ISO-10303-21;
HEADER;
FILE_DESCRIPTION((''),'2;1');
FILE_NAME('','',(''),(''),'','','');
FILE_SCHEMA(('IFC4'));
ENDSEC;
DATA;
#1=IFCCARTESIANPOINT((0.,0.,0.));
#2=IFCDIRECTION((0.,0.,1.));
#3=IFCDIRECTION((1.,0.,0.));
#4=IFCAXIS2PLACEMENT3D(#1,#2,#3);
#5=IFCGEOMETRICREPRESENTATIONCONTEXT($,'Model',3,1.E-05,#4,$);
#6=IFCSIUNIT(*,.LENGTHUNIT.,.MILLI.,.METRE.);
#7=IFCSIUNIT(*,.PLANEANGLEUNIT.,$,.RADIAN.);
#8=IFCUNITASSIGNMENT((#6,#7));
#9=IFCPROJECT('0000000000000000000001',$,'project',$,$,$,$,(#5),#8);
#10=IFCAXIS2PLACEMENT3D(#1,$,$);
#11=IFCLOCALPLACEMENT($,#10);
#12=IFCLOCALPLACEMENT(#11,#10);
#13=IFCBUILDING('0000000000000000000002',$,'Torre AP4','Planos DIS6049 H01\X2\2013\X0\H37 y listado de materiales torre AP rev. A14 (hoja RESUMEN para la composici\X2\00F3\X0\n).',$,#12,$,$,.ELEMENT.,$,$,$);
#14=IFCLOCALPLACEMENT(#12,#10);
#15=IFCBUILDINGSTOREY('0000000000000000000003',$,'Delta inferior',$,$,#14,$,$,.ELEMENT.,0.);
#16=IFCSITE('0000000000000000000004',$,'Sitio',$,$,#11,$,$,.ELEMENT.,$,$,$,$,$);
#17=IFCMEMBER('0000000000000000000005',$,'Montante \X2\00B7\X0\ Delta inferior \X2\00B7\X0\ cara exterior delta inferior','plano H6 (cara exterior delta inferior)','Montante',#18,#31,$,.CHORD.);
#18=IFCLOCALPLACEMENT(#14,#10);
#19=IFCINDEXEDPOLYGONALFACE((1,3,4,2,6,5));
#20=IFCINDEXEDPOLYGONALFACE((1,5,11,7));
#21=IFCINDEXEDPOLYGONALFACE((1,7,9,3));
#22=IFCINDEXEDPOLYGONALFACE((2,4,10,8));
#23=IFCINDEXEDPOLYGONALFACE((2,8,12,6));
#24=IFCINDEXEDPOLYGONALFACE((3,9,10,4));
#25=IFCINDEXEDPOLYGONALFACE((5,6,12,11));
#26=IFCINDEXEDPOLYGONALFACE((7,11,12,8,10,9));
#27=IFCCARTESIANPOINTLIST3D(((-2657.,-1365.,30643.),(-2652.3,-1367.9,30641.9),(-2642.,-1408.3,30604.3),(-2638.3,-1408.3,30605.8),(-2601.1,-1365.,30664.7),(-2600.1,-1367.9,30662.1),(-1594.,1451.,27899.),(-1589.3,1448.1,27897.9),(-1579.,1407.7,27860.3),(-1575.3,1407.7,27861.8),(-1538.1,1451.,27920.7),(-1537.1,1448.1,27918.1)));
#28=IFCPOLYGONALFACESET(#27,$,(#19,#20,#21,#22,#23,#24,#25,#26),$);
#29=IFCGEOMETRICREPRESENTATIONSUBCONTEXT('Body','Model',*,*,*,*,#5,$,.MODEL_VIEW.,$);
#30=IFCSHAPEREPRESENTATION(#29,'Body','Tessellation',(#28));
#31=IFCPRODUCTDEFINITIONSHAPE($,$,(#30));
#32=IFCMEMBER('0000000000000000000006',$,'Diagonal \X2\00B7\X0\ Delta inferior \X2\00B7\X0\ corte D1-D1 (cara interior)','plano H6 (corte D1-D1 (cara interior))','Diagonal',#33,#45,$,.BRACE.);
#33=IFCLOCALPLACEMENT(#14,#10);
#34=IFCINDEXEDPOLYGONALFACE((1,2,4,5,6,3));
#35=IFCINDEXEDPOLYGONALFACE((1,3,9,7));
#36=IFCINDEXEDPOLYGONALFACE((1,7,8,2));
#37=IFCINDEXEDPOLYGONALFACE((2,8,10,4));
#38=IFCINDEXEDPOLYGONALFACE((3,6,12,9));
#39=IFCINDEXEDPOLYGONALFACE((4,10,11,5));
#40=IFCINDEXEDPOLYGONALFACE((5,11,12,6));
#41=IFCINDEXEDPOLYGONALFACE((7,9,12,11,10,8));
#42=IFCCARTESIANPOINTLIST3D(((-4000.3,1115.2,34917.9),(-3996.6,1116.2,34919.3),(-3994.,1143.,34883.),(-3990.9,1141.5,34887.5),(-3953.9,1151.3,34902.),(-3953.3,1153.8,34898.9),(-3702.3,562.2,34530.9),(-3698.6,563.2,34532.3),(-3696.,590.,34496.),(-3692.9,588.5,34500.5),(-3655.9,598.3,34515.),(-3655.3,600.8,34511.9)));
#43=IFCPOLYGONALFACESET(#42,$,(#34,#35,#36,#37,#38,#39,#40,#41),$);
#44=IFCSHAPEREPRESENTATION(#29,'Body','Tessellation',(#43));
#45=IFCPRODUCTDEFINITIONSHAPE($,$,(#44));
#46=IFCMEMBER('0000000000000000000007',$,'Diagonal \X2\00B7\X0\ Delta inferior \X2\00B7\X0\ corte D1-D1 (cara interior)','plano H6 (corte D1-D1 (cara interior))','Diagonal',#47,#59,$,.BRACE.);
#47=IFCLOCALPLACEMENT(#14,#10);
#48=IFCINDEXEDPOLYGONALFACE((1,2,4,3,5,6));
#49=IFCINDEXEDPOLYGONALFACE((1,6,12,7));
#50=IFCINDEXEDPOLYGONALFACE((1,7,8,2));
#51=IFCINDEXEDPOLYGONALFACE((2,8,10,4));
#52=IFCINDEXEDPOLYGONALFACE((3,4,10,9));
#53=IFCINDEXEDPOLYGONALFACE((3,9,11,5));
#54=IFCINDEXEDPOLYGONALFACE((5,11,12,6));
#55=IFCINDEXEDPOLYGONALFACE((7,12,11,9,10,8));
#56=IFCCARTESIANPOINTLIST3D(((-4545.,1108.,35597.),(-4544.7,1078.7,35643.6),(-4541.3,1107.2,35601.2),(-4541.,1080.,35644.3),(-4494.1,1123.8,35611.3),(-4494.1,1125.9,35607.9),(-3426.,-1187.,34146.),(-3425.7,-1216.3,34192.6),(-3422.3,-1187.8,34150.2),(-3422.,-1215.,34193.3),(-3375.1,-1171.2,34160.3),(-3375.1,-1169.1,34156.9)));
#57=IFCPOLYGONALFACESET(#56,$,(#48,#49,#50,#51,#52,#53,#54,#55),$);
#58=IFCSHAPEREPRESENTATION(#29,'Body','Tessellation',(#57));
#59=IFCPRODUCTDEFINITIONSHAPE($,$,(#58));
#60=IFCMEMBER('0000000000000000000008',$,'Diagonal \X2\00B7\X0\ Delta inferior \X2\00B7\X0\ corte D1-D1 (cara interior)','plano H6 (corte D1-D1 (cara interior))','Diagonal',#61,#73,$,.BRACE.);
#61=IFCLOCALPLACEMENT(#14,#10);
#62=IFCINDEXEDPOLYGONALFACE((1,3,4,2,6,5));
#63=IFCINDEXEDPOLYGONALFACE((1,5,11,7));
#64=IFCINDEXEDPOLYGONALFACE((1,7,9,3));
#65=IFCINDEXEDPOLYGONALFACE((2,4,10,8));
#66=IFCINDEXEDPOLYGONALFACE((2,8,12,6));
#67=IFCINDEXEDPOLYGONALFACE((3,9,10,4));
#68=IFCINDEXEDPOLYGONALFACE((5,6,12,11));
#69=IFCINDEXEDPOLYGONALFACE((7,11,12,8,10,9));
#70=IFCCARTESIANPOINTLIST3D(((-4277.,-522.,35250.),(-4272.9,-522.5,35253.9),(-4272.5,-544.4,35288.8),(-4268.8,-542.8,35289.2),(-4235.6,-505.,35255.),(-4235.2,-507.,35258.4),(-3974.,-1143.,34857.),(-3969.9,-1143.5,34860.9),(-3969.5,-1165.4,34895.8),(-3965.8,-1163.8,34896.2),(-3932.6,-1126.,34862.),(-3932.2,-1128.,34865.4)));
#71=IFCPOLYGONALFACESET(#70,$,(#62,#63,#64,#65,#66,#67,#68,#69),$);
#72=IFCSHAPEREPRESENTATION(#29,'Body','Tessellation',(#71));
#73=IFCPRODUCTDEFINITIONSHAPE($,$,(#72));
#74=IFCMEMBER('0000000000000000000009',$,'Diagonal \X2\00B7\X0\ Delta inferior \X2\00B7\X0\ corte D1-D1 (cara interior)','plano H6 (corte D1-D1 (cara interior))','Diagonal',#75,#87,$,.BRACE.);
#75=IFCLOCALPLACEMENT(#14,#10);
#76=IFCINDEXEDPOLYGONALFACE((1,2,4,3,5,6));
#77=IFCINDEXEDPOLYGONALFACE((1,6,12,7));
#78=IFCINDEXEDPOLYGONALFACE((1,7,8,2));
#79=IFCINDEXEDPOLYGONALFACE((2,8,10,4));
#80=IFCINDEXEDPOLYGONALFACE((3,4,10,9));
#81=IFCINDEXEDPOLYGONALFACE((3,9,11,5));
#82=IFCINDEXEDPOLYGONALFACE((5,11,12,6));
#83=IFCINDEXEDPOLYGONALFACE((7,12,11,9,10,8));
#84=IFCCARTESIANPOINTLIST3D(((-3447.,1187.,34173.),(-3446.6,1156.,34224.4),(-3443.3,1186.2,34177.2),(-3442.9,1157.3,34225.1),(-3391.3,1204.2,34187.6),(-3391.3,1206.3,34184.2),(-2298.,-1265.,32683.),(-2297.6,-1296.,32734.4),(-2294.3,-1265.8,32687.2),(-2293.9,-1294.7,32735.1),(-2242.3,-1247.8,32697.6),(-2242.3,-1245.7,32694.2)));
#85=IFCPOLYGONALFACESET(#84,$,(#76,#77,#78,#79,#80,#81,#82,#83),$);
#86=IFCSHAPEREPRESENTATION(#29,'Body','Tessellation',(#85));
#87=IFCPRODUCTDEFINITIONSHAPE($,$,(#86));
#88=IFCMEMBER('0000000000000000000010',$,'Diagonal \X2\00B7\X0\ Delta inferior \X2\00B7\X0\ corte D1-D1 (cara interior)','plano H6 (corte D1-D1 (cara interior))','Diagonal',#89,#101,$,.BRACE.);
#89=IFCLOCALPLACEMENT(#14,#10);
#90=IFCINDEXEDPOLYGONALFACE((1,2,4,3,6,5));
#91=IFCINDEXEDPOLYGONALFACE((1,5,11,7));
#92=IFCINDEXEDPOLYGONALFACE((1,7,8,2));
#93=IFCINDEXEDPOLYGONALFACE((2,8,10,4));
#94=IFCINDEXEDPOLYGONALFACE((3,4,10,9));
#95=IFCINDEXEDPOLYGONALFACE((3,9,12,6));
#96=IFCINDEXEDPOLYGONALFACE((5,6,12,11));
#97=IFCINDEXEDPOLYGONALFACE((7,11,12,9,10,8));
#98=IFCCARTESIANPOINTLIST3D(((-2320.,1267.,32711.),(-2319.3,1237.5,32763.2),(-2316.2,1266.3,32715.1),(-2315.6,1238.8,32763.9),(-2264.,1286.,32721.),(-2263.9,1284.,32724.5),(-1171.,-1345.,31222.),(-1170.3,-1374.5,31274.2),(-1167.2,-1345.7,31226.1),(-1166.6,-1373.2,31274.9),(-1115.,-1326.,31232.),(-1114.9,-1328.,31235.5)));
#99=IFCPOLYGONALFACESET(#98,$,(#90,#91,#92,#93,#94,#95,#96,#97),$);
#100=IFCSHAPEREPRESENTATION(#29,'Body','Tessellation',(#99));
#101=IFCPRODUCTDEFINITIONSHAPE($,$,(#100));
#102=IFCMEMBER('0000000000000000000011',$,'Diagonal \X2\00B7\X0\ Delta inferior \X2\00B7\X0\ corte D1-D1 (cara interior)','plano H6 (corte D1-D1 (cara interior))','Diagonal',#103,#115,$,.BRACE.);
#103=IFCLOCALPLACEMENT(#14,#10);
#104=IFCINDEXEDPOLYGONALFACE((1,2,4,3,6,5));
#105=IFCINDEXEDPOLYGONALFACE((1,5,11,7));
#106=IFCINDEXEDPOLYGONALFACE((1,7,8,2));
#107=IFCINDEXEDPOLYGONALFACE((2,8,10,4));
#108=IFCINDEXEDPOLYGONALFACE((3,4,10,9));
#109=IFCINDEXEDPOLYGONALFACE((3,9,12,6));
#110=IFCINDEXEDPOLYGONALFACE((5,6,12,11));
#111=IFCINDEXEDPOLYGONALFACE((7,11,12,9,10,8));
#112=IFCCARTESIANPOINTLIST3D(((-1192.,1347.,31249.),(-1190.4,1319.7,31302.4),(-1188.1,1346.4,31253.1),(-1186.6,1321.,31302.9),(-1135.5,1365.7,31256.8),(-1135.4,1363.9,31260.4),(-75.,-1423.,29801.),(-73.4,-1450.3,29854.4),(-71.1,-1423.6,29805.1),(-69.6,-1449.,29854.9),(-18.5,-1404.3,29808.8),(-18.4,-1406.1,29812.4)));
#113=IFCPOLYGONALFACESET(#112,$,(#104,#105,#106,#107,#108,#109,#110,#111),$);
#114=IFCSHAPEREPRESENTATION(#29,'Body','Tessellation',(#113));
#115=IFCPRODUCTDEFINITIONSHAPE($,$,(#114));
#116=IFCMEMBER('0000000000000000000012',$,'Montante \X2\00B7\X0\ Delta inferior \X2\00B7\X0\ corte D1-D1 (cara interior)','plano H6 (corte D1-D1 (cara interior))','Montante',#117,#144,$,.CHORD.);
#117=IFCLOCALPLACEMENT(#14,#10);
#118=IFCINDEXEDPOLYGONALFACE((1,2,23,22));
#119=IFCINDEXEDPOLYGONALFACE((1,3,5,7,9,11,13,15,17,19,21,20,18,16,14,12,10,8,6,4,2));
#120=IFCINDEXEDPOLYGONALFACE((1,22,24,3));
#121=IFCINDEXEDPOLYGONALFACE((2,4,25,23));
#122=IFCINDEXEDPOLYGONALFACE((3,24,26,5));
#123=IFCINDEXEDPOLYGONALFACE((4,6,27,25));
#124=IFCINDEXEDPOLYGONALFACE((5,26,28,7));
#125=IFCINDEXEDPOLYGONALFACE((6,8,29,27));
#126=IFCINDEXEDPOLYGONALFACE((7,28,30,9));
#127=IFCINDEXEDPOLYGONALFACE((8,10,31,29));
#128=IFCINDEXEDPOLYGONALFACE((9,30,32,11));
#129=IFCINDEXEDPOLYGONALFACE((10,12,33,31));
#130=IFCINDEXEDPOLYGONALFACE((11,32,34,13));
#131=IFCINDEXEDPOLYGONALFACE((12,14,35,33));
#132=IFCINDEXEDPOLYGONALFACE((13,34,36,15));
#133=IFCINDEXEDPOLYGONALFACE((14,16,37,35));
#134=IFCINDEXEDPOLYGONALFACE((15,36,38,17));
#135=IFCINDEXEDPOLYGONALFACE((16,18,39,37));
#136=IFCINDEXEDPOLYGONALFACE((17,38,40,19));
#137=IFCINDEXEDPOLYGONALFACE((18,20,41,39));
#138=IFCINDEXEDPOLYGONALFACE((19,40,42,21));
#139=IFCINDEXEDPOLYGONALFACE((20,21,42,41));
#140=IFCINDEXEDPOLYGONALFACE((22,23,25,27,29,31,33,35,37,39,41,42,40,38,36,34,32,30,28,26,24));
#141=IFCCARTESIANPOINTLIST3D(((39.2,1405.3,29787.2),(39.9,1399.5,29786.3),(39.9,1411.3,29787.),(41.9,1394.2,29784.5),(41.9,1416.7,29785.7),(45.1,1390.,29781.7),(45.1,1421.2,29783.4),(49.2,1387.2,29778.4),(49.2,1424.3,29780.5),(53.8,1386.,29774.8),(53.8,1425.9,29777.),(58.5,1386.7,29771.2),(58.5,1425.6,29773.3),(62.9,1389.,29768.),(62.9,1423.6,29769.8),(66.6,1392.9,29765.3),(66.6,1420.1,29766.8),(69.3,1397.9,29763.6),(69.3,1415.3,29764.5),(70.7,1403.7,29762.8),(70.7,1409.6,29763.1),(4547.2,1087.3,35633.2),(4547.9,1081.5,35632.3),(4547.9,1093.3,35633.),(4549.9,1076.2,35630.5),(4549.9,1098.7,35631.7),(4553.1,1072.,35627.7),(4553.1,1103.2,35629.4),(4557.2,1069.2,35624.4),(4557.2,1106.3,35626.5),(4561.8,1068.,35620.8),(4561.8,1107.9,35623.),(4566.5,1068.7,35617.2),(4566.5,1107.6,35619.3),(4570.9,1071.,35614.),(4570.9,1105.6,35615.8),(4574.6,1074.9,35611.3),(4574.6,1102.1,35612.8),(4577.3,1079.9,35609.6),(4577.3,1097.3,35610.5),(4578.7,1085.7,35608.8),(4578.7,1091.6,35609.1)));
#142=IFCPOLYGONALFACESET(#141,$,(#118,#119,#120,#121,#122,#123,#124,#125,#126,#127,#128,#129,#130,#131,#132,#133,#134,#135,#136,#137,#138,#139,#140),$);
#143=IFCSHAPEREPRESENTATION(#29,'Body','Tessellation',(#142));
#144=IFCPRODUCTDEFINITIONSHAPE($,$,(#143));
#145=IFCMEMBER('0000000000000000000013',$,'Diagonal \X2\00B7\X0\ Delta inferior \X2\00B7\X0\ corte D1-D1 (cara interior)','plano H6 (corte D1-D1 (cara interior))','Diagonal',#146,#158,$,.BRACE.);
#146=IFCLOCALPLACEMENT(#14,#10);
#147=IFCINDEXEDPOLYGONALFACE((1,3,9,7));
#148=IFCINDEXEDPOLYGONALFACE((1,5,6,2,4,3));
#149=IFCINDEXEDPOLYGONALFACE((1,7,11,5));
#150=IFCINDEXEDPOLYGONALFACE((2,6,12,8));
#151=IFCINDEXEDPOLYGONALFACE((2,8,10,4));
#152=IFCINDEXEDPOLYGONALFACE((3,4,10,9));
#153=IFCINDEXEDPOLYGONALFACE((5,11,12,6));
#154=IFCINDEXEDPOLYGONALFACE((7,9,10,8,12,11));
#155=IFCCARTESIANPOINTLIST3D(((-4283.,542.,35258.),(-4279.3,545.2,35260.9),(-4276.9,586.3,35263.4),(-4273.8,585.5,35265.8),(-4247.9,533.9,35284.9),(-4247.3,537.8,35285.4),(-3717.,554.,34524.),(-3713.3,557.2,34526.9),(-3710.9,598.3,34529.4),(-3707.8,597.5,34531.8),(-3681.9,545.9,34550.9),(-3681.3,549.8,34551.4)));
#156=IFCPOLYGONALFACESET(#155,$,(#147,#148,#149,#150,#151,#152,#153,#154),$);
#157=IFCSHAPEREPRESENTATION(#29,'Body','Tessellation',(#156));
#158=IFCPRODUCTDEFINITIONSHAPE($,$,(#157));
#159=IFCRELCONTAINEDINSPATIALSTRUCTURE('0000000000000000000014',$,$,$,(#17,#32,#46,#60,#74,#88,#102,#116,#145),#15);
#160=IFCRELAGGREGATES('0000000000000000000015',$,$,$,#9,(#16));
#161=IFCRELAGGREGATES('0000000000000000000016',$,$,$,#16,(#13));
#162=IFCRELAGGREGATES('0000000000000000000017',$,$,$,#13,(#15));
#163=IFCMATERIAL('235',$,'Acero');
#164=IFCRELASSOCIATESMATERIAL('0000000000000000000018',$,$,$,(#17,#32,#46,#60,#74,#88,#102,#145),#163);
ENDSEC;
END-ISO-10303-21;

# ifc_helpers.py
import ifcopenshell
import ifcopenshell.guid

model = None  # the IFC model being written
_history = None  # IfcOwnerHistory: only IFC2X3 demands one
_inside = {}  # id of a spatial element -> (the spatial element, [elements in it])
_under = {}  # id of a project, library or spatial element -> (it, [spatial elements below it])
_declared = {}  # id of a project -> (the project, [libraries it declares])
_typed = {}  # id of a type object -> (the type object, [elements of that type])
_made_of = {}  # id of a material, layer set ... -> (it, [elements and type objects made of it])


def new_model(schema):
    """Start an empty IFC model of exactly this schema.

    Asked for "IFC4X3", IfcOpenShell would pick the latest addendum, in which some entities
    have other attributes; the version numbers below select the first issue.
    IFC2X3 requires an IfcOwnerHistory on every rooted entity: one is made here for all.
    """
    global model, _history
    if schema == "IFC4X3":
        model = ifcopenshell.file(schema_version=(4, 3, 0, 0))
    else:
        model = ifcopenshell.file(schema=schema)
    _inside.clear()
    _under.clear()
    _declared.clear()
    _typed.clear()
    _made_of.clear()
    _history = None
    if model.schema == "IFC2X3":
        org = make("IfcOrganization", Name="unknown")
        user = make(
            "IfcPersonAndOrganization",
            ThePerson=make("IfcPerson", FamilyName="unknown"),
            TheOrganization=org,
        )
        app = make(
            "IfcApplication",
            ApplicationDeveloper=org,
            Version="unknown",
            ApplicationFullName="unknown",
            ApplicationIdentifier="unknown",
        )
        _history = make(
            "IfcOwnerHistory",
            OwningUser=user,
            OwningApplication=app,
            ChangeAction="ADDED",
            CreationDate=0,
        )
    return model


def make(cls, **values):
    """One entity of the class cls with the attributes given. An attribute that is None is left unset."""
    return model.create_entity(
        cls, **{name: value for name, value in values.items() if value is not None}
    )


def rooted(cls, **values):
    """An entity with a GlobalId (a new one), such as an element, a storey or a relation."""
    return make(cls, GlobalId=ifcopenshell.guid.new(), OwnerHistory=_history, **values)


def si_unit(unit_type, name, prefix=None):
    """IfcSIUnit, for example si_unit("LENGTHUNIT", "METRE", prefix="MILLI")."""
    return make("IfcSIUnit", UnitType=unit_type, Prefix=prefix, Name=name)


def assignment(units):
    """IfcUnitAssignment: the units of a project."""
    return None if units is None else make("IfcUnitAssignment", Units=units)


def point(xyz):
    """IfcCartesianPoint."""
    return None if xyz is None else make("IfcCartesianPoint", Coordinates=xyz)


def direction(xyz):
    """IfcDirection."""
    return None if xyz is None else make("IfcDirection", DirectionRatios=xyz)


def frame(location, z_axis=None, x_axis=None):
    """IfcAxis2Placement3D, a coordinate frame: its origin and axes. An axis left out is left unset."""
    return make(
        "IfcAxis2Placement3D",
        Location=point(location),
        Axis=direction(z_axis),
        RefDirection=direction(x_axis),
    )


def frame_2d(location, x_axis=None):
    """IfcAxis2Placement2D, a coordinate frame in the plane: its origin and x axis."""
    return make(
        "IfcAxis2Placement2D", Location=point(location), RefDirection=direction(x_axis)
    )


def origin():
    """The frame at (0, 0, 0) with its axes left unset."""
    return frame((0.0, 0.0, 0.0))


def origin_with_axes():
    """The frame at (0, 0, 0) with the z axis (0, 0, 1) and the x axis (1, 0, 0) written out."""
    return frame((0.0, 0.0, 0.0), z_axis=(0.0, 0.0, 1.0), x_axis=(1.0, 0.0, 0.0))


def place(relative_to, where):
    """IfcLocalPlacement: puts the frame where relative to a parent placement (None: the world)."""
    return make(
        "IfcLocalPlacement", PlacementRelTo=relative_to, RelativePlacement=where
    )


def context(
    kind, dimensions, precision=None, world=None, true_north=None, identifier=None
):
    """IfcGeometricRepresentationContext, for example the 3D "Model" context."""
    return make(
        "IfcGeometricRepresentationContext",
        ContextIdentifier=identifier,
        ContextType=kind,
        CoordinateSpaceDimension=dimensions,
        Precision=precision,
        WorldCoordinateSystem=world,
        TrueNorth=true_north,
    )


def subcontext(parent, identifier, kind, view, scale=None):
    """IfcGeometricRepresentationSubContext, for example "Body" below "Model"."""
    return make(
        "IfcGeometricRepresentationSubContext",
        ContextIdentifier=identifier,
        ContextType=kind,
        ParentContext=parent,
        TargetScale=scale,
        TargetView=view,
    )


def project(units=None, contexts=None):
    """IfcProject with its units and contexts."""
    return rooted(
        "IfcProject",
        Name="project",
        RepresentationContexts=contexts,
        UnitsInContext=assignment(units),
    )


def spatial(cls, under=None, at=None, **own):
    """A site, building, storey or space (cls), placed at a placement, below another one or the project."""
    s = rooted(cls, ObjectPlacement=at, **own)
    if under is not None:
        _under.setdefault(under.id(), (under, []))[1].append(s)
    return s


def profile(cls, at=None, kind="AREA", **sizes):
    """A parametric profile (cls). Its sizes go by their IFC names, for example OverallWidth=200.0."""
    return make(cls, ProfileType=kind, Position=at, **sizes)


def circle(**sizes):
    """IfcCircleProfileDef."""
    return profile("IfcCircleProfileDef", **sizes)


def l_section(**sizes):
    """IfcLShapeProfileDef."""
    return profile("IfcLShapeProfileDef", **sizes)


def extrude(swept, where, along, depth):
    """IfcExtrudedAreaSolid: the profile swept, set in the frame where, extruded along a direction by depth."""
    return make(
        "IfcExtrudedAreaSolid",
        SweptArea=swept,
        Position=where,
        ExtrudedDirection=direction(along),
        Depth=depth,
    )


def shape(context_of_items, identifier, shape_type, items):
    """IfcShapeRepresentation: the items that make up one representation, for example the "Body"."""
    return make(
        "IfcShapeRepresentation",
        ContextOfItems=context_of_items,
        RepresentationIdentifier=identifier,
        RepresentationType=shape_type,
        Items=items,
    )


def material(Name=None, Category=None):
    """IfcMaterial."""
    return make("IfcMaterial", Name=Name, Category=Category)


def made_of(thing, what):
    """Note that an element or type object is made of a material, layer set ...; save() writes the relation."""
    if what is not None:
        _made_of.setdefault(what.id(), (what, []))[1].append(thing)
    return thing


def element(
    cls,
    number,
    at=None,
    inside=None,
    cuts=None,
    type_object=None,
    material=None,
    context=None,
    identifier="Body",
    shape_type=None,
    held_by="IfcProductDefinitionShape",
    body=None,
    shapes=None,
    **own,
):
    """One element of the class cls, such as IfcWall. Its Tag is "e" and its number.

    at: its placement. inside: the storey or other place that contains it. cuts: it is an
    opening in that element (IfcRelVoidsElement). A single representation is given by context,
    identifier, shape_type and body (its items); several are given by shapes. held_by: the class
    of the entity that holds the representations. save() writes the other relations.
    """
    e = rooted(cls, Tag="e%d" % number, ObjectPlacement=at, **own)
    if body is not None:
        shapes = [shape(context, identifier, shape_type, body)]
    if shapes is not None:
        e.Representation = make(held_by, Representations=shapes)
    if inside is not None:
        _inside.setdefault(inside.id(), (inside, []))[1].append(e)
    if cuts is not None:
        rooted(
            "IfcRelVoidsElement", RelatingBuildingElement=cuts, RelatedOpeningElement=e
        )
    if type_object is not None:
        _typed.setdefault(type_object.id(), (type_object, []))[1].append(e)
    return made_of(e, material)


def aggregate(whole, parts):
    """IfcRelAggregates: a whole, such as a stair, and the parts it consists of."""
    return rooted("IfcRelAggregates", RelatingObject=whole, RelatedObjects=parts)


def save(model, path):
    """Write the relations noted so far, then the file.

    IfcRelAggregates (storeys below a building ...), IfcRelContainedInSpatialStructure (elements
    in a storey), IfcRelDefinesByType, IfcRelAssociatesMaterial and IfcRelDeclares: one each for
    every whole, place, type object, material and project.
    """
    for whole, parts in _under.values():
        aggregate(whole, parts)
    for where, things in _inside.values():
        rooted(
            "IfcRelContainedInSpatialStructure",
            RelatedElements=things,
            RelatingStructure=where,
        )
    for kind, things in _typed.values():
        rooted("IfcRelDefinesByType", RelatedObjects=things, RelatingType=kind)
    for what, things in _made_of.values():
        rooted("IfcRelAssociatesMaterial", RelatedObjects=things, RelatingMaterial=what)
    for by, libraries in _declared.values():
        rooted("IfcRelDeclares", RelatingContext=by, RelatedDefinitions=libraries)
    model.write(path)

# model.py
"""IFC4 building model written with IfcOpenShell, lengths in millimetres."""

from ifc_helpers import new_model, si_unit, frame, frame_2d, origin, origin_with_axes, place, context, subcontext, project, spatial, circle, l_section, extrude, material, element, save


model = new_model("IFC4")

# Units and contexts
model_context = context("Model", 3, precision=1e-05, world=origin_with_axes())
body_context = subcontext(model_context, "Body", "Model", "MODEL_VIEW")
ifc_project = project(units=[si_unit("LENGTHUNIT", "METRE", prefix="MILLI"), si_unit("PLANEANGLEUNIT", "RADIAN")], contexts=[model_context])

# Site, building, storey
site_placement = place(None, origin())
site = spatial("IfcSite", under=ifc_project, at=site_placement, Name="Sitio", CompositionType="ELEMENT")
building_placement = place(site_placement, origin())
building = spatial("IfcBuilding", under=site, at=building_placement, Name="Torre AP4", Description="Planos DIS6049 H01–H37 y listado de materiales torre AP rev. A14 (hoja RESUMEN para la composición).", CompositionType="ELEMENT")
storey_placement = place(building_placement, origin())
storey = spatial("IfcBuildingStorey", under=building, at=storey_placement, Name="Delta inferior", CompositionType="ELEMENT", Elevation=0.0)

# Members
ifc_material_1 = material(Name="235", Category="Acero")
member_1_placement = place(storey_placement, frame((-1594.0, 1451.0, 27899.0), z_axis=(-0.260987, -0.691382, 0.673704), x_axis=(0.249749, -0.72249, -0.644697)))
element("IfcMember", 1, at=member_1_placement, inside=storey, material=ifc_material_1, Name="Montante · Delta inferior · cara exterior delta inferior", Description="plano H6 (cara exterior delta inferior)", ObjectType="Montante", PredefinedType="CHORD", context=body_context, shape_type="SweptSolid", body=[
    extrude(l_section(Depth=60.0, Width=60.0, Thickness=4.0, at=frame_2d((30.0, 30.0))), None, (0.0, 0.0, 1.0), 4073.0),
])
member_2_placement = place(storey_placement, frame((-3994.0, 1143.0, 34883.0), z_axis=(0.403891, -0.749503, -0.524516), x_axis=(0.904178, 0.239916, 0.353414)))
element("IfcMember", 2, at=member_2_placement, inside=storey, material=ifc_material_1, Name="Diagonal · Delta inferior · corte D1-D1 (cara interior)", Description="plano H6 (corte D1-D1 (cara interior))", ObjectType="Diagonal", PredefinedType="BRACE", context=body_context, shape_type="SweptSolid", body=[
    extrude(l_section(Depth=45.0, Width=45.0, Thickness=4.0, at=frame_2d((22.5, 22.5))), None, (0.0, 0.0, 1.0), 737.8),
])
member_3_placement = place(storey_placement, frame((-4545.0, 1108.0, 35597.0), z_axis=(0.381032, -0.781472, -0.494081), x_axis=(0.924547, 0.325107, 0.198793)))
element("IfcMember", 3, at=member_3_placement, inside=storey, material=ifc_material_1, Name="Diagonal · Delta inferior · corte D1-D1 (cara interior)", Description="plano H6 (corte D1-D1 (cara interior))", ObjectType="Diagonal", PredefinedType="BRACE", context=body_context, shape_type="SweptSolid", body=[
    extrude(l_section(Depth=55.0, Width=55.0, Thickness=4.0, at=frame_2d((27.5, 27.5))), None, (0.0, 0.0, 1.0), 2936.8),
])
member_4_placement = place(storey_placement, frame((-4277.0, -522.0, 35250.0), z_axis=(0.38117, -0.78121, -0.494389), x_axis=(0.919056, 0.378167, 0.111023)))
element("IfcMember", 4, at=member_4_placement, inside=storey, material=ifc_material_1, Name="Diagonal · Delta inferior · corte D1-D1 (cara interior)", Description="plano H6 (corte D1-D1 (cara interior))", ObjectType="Diagonal", PredefinedType="BRACE", context=body_context, shape_type="SweptSolid", body=[
    extrude(l_section(Depth=45.0, Width=45.0, Thickness=4.0, at=frame_2d((22.5, 22.5))), None, (0.0, 0.0, 1.0), 794.9),
])
member_5_placement = place(storey_placement, frame((-3447.0, 1187.0, 34173.0), z_axis=(0.371757, -0.79334, -0.482087), x_axis=(0.928304, 0.321616, 0.18659)))
element("IfcMember", 5, at=member_5_placement, inside=storey, material=ifc_material_1, Name="Diagonal · Delta inferior · corte D1-D1 (cara interior)", Description="plano H6 (corte D1-D1 (cara interior))", ObjectType="Diagonal", PredefinedType="BRACE", context=body_context, shape_type="SweptSolid", body=[
    extrude(l_section(Depth=60.0, Width=60.0, Thickness=4.0, at=frame_2d((30.0, 30.0))), None, (0.0, 0.0, 1.0), 3090.7),
])
member_6_placement = place(storey_placement, frame((-2320.0, 1267.0, 32711.0), z_axis=(0.356979, -0.811514, -0.462613), x_axis=(0.934048, 0.315929, 0.166565)))
element("IfcMember", 6, at=member_6_placement, inside=storey, material=ifc_material_1, Name="Diagonal · Delta inferior · corte D1-D1 (cara interior)", Description="plano H6 (corte D1-D1 (cara interior))", ObjectType="Diagonal", PredefinedType="BRACE", context=body_context, shape_type="SweptSolid", body=[
    extrude(l_section(Depth=60.0, Width=60.0, Thickness=4.0, at=frame_2d((30.0, 30.0))), None, (0.0, 0.0, 1.0), 3218.7),
])
member_7_placement = place(storey_placement, frame((-1192.0, 1347.0, 31249.0), z_axis=(0.336524, -0.834531, -0.436246), x_axis=(0.94128, 0.311519, 0.130181)))
element("IfcMember", 7, at=member_7_placement, inside=storey, material=ifc_material_1, Name="Diagonal · Delta inferior · corte D1-D1 (cara interior)", Description="plano H6 (corte D1-D1 (cara interior))", ObjectType="Diagonal", PredefinedType="BRACE", context=body_context, shape_type="SweptSolid", body=[
    extrude(l_section(Depth=60.0, Width=60.0, Thickness=4.0, at=frame_2d((30.0, 30.0))), None, (0.0, 0.0, 1.0), 3319.2),
])
for number, where, z_axis, x_axis, name in (
    (8, (55.0, 1406.0, 29775.0), (0.610087, -0.043036, 0.791165), (-0.792334, -0.033137, 0.609187), "Montante · Delta inferior · corte D1-D1 (cara interior)"),
):
    element("IfcMember", number, at=place(storey_placement, frame(where, z_axis=z_axis, x_axis=x_axis)), inside=storey, Name=name, Description="plano H6 (corte D1-D1 (cara interior))", ObjectType="Montante", PredefinedType="CHORD", context=body_context, shape_type="SweptSolid", body=[
        extrude(circle(Radius=20.0), None, (0.0, 0.0, 1.0), 7389.1),
    ])
member_8_placement = place(storey_placement, frame((-3717.0, 554.0, 34524.0), z_axis=(-0.610598, -0.012946, 0.791835), x_axis=(0.780393, -0.179966, 0.598832)))
element("IfcMember", 9, at=member_8_placement, inside=storey, material=ifc_material_1, Name="Diagonal · Delta inferior · corte D1-D1 (cara interior)", Description="plano H6 (corte D1-D1 (cara interior))", ObjectType="Diagonal", PredefinedType="BRACE", context=body_context, shape_type="SweptSolid", body=[
    extrude(l_section(Depth=45.0, Width=45.0, Thickness=4.0, at=frame_2d((22.5, 22.5))), None, (0.0, 0.0, 1.0), 927.0),
])

save(model, "model.ifc")
